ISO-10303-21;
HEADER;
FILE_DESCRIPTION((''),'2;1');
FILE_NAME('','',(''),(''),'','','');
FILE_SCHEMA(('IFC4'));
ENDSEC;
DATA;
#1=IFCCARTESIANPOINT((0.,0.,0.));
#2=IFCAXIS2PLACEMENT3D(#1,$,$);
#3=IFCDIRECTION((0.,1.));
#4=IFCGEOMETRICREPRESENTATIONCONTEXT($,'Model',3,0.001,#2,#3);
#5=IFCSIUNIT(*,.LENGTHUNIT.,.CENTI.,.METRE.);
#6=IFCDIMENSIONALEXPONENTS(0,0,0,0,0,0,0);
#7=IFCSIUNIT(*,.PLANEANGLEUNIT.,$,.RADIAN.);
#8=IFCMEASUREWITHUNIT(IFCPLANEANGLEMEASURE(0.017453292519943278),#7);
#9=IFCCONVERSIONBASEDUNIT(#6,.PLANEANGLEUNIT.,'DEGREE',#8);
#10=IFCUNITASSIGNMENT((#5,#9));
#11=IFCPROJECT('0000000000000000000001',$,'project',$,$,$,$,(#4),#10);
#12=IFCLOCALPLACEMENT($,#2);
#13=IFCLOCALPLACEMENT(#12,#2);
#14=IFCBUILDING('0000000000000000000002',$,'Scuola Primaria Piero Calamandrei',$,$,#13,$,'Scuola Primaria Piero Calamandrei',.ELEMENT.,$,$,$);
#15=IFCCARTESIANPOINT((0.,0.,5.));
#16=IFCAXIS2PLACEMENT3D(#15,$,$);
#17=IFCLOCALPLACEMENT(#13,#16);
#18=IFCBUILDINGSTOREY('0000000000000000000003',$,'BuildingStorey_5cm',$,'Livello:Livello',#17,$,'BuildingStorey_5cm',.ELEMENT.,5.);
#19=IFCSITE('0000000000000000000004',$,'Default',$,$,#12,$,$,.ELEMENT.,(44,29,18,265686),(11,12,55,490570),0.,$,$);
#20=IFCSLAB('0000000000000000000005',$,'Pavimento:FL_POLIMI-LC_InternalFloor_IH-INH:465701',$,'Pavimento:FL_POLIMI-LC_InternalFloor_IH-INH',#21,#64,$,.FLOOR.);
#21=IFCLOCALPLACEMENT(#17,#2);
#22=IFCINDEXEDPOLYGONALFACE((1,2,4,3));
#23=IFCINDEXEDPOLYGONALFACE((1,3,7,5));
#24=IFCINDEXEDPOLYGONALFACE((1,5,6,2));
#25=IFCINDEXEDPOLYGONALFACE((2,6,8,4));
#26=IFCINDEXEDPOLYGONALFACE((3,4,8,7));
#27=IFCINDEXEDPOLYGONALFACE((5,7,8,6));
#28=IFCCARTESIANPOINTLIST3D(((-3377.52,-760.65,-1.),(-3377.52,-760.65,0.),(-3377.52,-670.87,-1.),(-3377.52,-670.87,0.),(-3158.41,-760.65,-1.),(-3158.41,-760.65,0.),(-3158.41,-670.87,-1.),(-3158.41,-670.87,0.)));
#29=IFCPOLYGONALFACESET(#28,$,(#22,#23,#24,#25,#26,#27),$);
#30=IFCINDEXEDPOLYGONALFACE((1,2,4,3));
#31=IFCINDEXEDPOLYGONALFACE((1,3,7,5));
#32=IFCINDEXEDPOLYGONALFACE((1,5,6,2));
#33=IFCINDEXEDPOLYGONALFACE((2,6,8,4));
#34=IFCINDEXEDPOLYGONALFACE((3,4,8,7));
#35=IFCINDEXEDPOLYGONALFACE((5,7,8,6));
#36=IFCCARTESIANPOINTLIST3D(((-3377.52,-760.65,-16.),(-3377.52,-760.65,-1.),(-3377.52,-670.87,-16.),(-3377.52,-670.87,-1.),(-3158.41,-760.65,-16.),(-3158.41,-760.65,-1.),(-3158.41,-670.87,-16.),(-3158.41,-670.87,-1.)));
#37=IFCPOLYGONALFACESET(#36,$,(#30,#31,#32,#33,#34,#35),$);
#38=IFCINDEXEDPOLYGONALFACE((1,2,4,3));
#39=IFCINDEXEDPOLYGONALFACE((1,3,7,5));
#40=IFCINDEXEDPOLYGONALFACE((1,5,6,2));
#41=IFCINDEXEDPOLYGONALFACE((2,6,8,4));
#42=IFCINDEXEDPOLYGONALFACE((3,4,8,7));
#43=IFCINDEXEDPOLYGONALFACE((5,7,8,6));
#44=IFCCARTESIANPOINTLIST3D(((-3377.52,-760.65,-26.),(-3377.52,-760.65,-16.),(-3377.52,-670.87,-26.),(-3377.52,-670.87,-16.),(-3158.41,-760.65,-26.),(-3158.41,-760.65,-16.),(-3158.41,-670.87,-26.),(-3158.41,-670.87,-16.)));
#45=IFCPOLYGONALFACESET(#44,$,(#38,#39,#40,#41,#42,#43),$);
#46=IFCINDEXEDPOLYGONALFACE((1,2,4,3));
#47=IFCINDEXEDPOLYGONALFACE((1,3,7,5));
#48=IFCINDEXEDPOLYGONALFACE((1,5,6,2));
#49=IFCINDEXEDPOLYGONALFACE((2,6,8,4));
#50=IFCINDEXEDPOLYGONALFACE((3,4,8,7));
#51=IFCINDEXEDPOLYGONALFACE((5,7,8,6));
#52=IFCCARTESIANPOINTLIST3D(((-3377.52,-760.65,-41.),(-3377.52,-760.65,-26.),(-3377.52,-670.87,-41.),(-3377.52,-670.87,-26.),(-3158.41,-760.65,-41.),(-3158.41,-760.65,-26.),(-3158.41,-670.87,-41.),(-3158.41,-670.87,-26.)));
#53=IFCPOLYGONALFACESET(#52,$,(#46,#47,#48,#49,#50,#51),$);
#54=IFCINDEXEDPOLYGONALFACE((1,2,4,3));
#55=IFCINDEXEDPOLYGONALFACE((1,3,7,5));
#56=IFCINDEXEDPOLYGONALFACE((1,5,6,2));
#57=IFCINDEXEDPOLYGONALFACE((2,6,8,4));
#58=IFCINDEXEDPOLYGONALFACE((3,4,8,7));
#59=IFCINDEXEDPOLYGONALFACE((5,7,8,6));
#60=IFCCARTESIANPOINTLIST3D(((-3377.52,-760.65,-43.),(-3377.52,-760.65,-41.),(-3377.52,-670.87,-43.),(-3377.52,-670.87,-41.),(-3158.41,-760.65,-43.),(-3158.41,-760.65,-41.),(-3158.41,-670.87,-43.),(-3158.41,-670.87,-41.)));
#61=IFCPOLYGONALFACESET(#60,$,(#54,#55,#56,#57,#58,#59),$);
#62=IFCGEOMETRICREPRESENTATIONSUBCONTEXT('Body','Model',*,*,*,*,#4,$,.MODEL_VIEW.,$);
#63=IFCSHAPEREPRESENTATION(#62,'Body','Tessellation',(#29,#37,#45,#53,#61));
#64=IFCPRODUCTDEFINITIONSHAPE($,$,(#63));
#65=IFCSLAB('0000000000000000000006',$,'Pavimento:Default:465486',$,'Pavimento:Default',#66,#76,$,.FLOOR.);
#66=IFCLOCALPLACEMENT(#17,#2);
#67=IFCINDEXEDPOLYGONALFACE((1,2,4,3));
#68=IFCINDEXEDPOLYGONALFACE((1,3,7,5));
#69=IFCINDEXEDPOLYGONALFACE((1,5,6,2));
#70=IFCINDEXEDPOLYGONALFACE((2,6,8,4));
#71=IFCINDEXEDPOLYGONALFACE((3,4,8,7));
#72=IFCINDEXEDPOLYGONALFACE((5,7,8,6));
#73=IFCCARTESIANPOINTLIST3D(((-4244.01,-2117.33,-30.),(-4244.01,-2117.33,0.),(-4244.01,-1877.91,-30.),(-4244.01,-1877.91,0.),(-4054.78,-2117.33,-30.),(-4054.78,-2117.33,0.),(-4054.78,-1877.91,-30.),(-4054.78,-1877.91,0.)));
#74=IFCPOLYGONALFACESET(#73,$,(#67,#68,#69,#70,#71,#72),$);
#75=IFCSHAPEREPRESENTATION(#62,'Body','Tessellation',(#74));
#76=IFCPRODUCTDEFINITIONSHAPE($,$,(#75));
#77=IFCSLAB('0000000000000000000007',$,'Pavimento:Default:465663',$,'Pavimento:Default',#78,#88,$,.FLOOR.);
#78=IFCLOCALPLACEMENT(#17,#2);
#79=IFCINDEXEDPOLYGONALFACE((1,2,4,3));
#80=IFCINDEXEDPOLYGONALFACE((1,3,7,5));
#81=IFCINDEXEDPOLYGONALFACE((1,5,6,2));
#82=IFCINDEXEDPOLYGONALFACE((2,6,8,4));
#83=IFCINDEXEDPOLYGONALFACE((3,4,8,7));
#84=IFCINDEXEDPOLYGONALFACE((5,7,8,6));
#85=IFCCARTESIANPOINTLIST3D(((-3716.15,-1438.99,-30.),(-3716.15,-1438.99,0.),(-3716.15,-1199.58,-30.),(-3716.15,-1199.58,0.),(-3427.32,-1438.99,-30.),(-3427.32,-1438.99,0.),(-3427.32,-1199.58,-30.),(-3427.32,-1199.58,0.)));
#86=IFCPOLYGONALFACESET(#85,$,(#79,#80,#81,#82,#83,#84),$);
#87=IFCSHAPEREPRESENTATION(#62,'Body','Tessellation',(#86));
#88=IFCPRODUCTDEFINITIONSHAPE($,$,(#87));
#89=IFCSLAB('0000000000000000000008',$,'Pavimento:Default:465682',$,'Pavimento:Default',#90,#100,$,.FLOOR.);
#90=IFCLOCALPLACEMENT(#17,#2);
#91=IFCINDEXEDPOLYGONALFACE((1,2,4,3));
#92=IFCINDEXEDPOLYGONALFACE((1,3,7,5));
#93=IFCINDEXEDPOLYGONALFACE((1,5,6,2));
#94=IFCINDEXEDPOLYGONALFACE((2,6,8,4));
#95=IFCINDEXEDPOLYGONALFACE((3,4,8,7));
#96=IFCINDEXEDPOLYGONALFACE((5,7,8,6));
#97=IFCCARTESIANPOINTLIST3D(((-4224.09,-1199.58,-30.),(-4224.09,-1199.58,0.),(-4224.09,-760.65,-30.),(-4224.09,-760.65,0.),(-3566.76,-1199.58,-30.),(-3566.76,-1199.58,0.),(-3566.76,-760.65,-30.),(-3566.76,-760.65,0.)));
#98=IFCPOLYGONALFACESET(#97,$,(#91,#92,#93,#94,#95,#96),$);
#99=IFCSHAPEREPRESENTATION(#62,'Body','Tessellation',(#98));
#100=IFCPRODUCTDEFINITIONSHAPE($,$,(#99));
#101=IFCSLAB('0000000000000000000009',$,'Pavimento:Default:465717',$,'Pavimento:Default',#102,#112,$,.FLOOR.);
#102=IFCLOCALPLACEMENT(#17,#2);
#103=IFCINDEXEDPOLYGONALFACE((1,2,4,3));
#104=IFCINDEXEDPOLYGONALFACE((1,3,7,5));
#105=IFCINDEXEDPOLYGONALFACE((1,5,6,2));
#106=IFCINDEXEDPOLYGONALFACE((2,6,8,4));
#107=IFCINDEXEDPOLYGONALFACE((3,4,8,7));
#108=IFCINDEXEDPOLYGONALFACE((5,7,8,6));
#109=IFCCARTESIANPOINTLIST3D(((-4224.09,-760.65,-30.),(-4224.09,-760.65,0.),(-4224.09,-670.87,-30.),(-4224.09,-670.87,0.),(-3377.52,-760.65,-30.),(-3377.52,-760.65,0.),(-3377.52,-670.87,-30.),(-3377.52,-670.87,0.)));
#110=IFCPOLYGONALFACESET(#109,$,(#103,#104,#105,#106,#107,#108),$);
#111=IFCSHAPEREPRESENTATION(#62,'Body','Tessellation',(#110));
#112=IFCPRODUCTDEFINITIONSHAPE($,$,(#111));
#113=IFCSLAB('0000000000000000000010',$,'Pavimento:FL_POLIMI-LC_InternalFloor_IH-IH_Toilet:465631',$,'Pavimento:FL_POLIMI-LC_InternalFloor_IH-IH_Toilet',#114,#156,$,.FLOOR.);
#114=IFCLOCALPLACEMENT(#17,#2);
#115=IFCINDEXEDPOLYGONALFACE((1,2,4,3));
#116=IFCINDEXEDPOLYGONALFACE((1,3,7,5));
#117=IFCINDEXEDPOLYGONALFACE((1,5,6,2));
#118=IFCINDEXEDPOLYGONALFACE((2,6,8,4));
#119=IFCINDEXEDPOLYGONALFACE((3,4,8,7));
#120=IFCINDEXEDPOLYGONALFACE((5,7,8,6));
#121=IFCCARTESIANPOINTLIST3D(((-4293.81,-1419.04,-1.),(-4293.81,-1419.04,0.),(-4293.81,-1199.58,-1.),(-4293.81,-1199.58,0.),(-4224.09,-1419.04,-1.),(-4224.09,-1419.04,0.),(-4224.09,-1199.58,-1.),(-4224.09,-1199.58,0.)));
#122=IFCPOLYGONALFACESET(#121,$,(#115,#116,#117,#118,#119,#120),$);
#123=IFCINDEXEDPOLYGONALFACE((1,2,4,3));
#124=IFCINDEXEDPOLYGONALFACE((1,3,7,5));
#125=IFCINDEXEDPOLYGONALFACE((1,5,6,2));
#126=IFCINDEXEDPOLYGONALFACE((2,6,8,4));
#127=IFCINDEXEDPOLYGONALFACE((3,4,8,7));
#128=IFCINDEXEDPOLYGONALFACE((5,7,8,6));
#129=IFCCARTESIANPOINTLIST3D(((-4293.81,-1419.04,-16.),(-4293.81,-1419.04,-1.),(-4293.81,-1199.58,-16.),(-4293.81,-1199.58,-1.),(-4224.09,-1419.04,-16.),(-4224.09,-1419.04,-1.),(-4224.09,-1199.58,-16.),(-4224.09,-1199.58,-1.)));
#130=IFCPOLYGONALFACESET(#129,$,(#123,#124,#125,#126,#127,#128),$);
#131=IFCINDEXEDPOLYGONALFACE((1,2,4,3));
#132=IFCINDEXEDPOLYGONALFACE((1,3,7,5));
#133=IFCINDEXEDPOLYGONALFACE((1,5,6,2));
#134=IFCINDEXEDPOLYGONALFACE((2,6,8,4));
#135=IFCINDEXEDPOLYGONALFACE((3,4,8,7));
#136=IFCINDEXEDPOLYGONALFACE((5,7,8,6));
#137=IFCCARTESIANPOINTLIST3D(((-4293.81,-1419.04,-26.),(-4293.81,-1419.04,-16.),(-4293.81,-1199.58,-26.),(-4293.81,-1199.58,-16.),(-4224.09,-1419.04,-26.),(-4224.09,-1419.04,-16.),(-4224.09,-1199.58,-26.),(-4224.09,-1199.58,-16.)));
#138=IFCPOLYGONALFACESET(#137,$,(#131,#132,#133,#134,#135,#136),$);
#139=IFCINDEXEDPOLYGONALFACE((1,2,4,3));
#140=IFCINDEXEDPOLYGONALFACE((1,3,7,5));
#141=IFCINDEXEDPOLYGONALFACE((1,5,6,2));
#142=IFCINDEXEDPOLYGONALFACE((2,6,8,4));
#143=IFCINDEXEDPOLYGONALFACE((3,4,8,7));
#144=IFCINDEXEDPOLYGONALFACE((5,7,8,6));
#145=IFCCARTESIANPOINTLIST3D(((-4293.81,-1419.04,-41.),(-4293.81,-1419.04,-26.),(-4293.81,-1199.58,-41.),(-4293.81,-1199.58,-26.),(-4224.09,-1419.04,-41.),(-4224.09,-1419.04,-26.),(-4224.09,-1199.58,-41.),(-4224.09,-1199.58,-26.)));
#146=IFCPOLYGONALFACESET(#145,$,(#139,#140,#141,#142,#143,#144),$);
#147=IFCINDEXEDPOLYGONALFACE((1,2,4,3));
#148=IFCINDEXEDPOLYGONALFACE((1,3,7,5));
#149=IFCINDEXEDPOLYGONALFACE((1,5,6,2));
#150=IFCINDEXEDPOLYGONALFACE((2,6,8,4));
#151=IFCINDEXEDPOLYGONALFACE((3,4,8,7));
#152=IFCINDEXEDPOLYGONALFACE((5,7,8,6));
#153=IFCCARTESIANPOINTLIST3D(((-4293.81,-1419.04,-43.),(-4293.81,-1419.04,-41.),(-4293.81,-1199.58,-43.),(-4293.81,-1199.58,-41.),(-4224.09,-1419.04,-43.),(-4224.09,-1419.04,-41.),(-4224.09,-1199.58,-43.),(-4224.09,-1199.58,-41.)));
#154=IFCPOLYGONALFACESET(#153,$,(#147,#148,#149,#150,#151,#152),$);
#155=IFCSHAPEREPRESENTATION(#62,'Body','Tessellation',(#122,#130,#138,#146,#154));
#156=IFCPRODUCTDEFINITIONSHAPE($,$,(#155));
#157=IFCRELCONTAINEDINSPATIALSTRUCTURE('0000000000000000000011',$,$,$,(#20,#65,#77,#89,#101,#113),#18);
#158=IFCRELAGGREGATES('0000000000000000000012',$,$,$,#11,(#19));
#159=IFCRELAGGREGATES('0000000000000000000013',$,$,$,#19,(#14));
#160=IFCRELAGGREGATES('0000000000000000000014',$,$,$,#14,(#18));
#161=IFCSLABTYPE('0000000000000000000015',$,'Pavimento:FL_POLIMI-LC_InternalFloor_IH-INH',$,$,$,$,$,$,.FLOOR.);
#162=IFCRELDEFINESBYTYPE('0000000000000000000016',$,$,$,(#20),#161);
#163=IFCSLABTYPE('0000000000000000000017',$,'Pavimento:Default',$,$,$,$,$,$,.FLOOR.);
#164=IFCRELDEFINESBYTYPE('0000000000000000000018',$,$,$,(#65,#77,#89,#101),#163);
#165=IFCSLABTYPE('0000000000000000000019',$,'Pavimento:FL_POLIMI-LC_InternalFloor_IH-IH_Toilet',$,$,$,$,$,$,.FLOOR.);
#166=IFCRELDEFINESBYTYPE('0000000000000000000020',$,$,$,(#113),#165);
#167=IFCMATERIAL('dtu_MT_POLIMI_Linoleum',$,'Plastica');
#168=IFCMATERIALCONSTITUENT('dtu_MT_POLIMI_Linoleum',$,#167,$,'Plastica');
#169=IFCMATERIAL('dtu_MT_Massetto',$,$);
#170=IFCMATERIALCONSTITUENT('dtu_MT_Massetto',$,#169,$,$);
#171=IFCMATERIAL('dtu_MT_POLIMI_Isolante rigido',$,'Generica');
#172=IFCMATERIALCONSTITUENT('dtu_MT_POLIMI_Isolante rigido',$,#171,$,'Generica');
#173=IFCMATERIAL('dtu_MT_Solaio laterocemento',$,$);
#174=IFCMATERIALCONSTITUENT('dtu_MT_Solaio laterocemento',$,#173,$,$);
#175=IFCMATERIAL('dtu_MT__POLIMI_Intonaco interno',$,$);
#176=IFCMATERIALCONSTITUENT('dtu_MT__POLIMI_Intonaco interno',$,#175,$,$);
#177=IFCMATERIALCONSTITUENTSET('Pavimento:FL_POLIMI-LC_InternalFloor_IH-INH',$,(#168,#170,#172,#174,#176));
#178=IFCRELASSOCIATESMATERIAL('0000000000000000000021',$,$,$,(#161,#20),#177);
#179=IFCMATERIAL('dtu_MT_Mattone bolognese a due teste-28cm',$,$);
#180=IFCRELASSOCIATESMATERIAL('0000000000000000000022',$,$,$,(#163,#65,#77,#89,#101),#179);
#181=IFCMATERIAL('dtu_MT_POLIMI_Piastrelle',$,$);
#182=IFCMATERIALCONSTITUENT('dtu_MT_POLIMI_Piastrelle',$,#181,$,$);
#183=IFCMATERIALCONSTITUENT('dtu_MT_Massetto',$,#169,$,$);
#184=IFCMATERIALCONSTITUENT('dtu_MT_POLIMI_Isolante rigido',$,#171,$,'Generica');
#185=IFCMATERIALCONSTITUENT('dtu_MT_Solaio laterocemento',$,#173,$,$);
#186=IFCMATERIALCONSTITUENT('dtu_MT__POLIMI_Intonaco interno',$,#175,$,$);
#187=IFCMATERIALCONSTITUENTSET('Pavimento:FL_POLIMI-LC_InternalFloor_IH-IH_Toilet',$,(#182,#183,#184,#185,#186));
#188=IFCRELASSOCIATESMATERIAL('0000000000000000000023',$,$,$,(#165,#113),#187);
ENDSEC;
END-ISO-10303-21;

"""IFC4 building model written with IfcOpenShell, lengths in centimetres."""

from ifc_helpers import new_model, entity, si_unit, converted_unit, direction, frame, origin, place, context, subcontext, project, spatial, indexed_curve, outline, extrude, material, constituent, constituent_set, type_object, element, save


model = new_model("IFC4")

# Units and contexts
model_context = context("Model", 3, precision=0.001, world=origin(), true_north=direction((0.0, 1.0)))
body_context = subcontext(model_context, "Body", "Model", "MODEL_VIEW")
ifc_project = project(units=[si_unit("LENGTHUNIT", "METRE", prefix="CENTI"), converted_unit("PLANEANGLEUNIT", "DEGREE", entity("IfcPlaneAngleMeasure", 0.017453292519943278), si_unit("PLANEANGLEUNIT", "RADIAN"), dimensions=[0, 0, 0, 0, 0, 0, 0])], contexts=[model_context])

# Site, building, storey
site_placement = place(None, origin())
site = spatial("IfcSite", under=ifc_project, at=site_placement, Name="Default", CompositionType="ELEMENT", RefLatitude=(44, 29, 18, 265686), RefLongitude=(11, 12, 55, 490570), RefElevation=0.0)
building_placement = place(site_placement, origin())
building = spatial("IfcBuilding", under=site, at=building_placement, Name="Scuola Primaria Piero Calamandrei", LongName="Scuola Primaria Piero Calamandrei", CompositionType="ELEMENT")
storey_placement = place(building_placement, frame((0.0, 0.0, 5.0)))
storey = spatial("IfcBuildingStorey", under=building, at=storey_placement, Name="BuildingStorey_5cm", ObjectType="Livello:Livello", LongName="BuildingStorey_5cm", CompositionType="ELEMENT", Elevation=5.0)

# Slabs
ifc_material_1 = material(Name="dtu_MT_POLIMI_Linoleum", Category="Plastica")
ifc_constituent_1 = constituent(ifc_material_1, Name="dtu_MT_POLIMI_Linoleum", Category="Plastica")
ifc_material_2 = material(Name="dtu_MT_Massetto")
ifc_constituent_2 = constituent(ifc_material_2, Name="dtu_MT_Massetto")
ifc_material_3 = material(Name="dtu_MT_POLIMI_Isolante rigido", Category="Generica")
ifc_constituent_3 = constituent(ifc_material_3, Name="dtu_MT_POLIMI_Isolante rigido", Category="Generica")
ifc_material_4 = material(Name="dtu_MT_Solaio laterocemento")
ifc_constituent_4 = constituent(ifc_material_4, Name="dtu_MT_Solaio laterocemento")
ifc_material_5 = material(Name="dtu_MT__POLIMI_Intonaco interno")
ifc_constituent_5 = constituent(ifc_material_5, Name="dtu_MT__POLIMI_Intonaco interno")
ifc_constituent_set_1 = constituent_set(constituents=[ifc_constituent_1, ifc_constituent_2, ifc_constituent_3, ifc_constituent_4, ifc_constituent_5], Name="Pavimento:FL_POLIMI-LC_InternalFloor_IH-INH")
slab_type_1 = type_object("IfcSlabType", Name="Pavimento:FL_POLIMI-LC_InternalFloor_IH-INH", PredefinedType="FLOOR", material=ifc_constituent_set_1)
slab_1_placement = place(storey_placement, origin())
element("IfcSlab", 1, at=slab_1_placement, inside=storey, type_object=slab_type_1, material=ifc_constituent_set_1, Name="Pavimento:FL_POLIMI-LC_InternalFloor_IH-INH:465701", ObjectType="Pavimento:FL_POLIMI-LC_InternalFloor_IH-INH", PredefinedType="FLOOR", context=body_context, shape_type="SweptSolid", body=[
    extrude(outline(indexed_curve([(-44.89, -109.56), (44.89, -109.56), (44.89, 109.56), (-44.89, 109.56), (-44.89, -109.56)], self_intersect=False)), frame((-3267.97, -715.76, -1.0), z_axis=(0.0, 0.0, 1.0), x_axis=(0.0, -1.0, 0.0)), (0.0, 0.0, 1.0), 1.0),
    extrude(outline(indexed_curve([(-44.89, -109.56), (44.89, -109.56), (44.89, 109.56), (-44.89, 109.56), (-44.89, -109.56)], self_intersect=False)), frame((-3267.97, -715.76, -16.0), z_axis=(0.0, 0.0, 1.0), x_axis=(0.0, -1.0, 0.0)), (0.0, 0.0, 1.0), 15.0),
    extrude(outline(indexed_curve([(-44.89, -109.56), (44.89, -109.56), (44.89, 109.56), (-44.89, 109.56), (-44.89, -109.56)], self_intersect=False)), frame((-3267.97, -715.76, -26.0), z_axis=(0.0, 0.0, 1.0), x_axis=(0.0, -1.0, 0.0)), (0.0, 0.0, 1.0), 10.0),
    extrude(outline(indexed_curve([(-44.89, -109.56), (44.89, -109.56), (44.89, 109.56), (-44.89, 109.56), (-44.89, -109.56)], self_intersect=False)), frame((-3267.97, -715.76, -41.0), z_axis=(0.0, 0.0, 1.0), x_axis=(0.0, -1.0, 0.0)), (0.0, 0.0, 1.0), 15.0),
    extrude(outline(indexed_curve([(-44.89, -109.56), (44.89, -109.56), (44.89, 109.56), (-44.89, 109.56), (-44.89, -109.56)], self_intersect=False)), frame((-3267.97, -715.76, -43.0), z_axis=(0.0, 0.0, 1.0), x_axis=(0.0, -1.0, 0.0)), (0.0, 0.0, 1.0), 2.0),
])
ifc_material_6 = material(Name="dtu_MT_Mattone bolognese a due teste-28cm")
slab_type_2 = type_object("IfcSlabType", Name="Pavimento:Default", PredefinedType="FLOOR", material=ifc_material_6)
slab_2_placement = place(storey_placement, origin())
element("IfcSlab", 2, at=slab_2_placement, inside=storey, type_object=slab_type_2, material=ifc_material_6, Name="Pavimento:Default:465486", ObjectType="Pavimento:Default", PredefinedType="FLOOR", context=body_context, shape_type="SweptSolid", body=[
    extrude(outline(indexed_curve([(-119.71, -94.62), (119.71, -94.62), (119.71, 94.62), (-119.71, 94.62), (-119.71, -94.62)], self_intersect=False)), frame((-4149.39, -1997.62, 0.0), z_axis=(0.0, 0.0, -1.0), x_axis=(0.0, 1.0, 0.0)), (0.0, 0.0, 1.0), 30.0),
])
slab_3_placement = place(storey_placement, origin())
element("IfcSlab", 3, at=slab_3_placement, inside=storey, type_object=slab_type_2, material=ifc_material_6, Name="Pavimento:Default:465663", ObjectType="Pavimento:Default", PredefinedType="FLOOR", context=body_context, shape_type="SweptSolid", body=[
    extrude(outline(indexed_curve([(-119.71, -144.41), (119.71, -144.41), (119.71, 144.41), (-119.71, 144.41), (-119.71, -144.41)], self_intersect=False)), frame((-3571.74, -1319.28, 0.0), z_axis=(0.0, 0.0, -1.0), x_axis=(0.0, 1.0, 0.0)), (0.0, 0.0, 1.0), 30.0),
])
slab_4_placement = place(storey_placement, origin())
element("IfcSlab", 4, at=slab_4_placement, inside=storey, type_object=slab_type_2, material=ifc_material_6, Name="Pavimento:Default:465682", ObjectType="Pavimento:Default", PredefinedType="FLOOR", context=body_context, shape_type="SweptSolid", body=[
    extrude(outline(indexed_curve([(-219.46, -328.67), (219.46, -328.67), (219.46, 328.67), (-219.46, 328.67), (-219.46, -328.67)], self_intersect=False)), frame((-3895.42, -980.11, 0.0), z_axis=(0.0, 0.0, -1.0), x_axis=(0.0, 1.0, 0.0)), (0.0, 0.0, 1.0), 30.0),
])
slab_5_placement = place(storey_placement, origin())
element("IfcSlab", 5, at=slab_5_placement, inside=storey, type_object=slab_type_2, material=ifc_material_6, Name="Pavimento:Default:465717", ObjectType="Pavimento:Default", PredefinedType="FLOOR", context=body_context, shape_type="SweptSolid", body=[
    extrude(outline(indexed_curve([(-44.89, -423.28), (44.89, -423.28), (44.89, 423.28), (-44.89, 423.28), (-44.89, -423.28)], self_intersect=False)), frame((-3800.81, -715.76, 0.0), z_axis=(0.0, 0.0, -1.0), x_axis=(0.0, 1.0, 0.0)), (0.0, 0.0, 1.0), 30.0),
])
ifc_material_7 = material(Name="dtu_MT_POLIMI_Piastrelle")
ifc_constituent_6 = constituent(ifc_material_7, Name="dtu_MT_POLIMI_Piastrelle")
ifc_constituent_7 = constituent(ifc_material_2, Name="dtu_MT_Massetto")
ifc_constituent_8 = constituent(ifc_material_3, Name="dtu_MT_POLIMI_Isolante rigido", Category="Generica")
ifc_constituent_9 = constituent(ifc_material_4, Name="dtu_MT_Solaio laterocemento")
ifc_constituent_10 = constituent(ifc_material_5, Name="dtu_MT__POLIMI_Intonaco interno")
ifc_constituent_set_2 = constituent_set(constituents=[ifc_constituent_6, ifc_constituent_7, ifc_constituent_8, ifc_constituent_9, ifc_constituent_10], Name="Pavimento:FL_POLIMI-LC_InternalFloor_IH-IH_Toilet")
slab_type_3 = type_object("IfcSlabType", Name="Pavimento:FL_POLIMI-LC_InternalFloor_IH-IH_Toilet", PredefinedType="FLOOR", material=ifc_constituent_set_2)
slab_6_placement = place(storey_placement, origin())
element("IfcSlab", 6, at=slab_6_placement, inside=storey, type_object=slab_type_3, material=ifc_constituent_set_2, Name="Pavimento:FL_POLIMI-LC_InternalFloor_IH-IH_Toilet:465631", ObjectType="Pavimento:FL_POLIMI-LC_InternalFloor_IH-IH_Toilet", PredefinedType="FLOOR", context=body_context, shape_type="SweptSolid", body=[
    extrude(outline(indexed_curve([(-109.73, -34.86), (109.73, -34.86), (109.73, 34.86), (-109.73, 34.86), (-109.73, -34.86)], self_intersect=False)), frame((-4258.95, -1309.31, -1.0), z_axis=(0.0, 0.0, 1.0), x_axis=(0.0, 1.0, 0.0)), (0.0, 0.0, 1.0), 1.0),
    extrude(outline(indexed_curve([(-109.73, -34.86), (109.73, -34.86), (109.73, 34.86), (-109.73, 34.86), (-109.73, -34.86)], self_intersect=False)), frame((-4258.95, -1309.31, -16.0), z_axis=(0.0, 0.0, 1.0), x_axis=(0.0, 1.0, 0.0)), (0.0, 0.0, 1.0), 15.0),
    extrude(outline(indexed_curve([(-109.73, -34.86), (109.73, -34.86), (109.73, 34.86), (-109.73, 34.86), (-109.73, -34.86)], self_intersect=False)), frame((-4258.95, -1309.31, -26.0), z_axis=(0.0, 0.0, 1.0), x_axis=(0.0, 1.0, 0.0)), (0.0, 0.0, 1.0), 10.0),
    extrude(outline(indexed_curve([(-109.73, -34.86), (109.73, -34.86), (109.73, 34.86), (-109.73, 34.86), (-109.73, -34.86)], self_intersect=False)), frame((-4258.95, -1309.31, -41.0), z_axis=(0.0, 0.0, 1.0), x_axis=(0.0, 1.0, 0.0)), (0.0, 0.0, 1.0), 15.0),
    extrude(outline(indexed_curve([(-109.73, -34.86), (109.73, -34.86), (109.73, 34.86), (-109.73, 34.86), (-109.73, -34.86)], self_intersect=False)), frame((-4258.95, -1309.31, -43.0), z_axis=(0.0, 0.0, 1.0), x_axis=(0.0, 1.0, 0.0)), (0.0, 0.0, 1.0), 2.0),
])

save(model, "model.ifc")
